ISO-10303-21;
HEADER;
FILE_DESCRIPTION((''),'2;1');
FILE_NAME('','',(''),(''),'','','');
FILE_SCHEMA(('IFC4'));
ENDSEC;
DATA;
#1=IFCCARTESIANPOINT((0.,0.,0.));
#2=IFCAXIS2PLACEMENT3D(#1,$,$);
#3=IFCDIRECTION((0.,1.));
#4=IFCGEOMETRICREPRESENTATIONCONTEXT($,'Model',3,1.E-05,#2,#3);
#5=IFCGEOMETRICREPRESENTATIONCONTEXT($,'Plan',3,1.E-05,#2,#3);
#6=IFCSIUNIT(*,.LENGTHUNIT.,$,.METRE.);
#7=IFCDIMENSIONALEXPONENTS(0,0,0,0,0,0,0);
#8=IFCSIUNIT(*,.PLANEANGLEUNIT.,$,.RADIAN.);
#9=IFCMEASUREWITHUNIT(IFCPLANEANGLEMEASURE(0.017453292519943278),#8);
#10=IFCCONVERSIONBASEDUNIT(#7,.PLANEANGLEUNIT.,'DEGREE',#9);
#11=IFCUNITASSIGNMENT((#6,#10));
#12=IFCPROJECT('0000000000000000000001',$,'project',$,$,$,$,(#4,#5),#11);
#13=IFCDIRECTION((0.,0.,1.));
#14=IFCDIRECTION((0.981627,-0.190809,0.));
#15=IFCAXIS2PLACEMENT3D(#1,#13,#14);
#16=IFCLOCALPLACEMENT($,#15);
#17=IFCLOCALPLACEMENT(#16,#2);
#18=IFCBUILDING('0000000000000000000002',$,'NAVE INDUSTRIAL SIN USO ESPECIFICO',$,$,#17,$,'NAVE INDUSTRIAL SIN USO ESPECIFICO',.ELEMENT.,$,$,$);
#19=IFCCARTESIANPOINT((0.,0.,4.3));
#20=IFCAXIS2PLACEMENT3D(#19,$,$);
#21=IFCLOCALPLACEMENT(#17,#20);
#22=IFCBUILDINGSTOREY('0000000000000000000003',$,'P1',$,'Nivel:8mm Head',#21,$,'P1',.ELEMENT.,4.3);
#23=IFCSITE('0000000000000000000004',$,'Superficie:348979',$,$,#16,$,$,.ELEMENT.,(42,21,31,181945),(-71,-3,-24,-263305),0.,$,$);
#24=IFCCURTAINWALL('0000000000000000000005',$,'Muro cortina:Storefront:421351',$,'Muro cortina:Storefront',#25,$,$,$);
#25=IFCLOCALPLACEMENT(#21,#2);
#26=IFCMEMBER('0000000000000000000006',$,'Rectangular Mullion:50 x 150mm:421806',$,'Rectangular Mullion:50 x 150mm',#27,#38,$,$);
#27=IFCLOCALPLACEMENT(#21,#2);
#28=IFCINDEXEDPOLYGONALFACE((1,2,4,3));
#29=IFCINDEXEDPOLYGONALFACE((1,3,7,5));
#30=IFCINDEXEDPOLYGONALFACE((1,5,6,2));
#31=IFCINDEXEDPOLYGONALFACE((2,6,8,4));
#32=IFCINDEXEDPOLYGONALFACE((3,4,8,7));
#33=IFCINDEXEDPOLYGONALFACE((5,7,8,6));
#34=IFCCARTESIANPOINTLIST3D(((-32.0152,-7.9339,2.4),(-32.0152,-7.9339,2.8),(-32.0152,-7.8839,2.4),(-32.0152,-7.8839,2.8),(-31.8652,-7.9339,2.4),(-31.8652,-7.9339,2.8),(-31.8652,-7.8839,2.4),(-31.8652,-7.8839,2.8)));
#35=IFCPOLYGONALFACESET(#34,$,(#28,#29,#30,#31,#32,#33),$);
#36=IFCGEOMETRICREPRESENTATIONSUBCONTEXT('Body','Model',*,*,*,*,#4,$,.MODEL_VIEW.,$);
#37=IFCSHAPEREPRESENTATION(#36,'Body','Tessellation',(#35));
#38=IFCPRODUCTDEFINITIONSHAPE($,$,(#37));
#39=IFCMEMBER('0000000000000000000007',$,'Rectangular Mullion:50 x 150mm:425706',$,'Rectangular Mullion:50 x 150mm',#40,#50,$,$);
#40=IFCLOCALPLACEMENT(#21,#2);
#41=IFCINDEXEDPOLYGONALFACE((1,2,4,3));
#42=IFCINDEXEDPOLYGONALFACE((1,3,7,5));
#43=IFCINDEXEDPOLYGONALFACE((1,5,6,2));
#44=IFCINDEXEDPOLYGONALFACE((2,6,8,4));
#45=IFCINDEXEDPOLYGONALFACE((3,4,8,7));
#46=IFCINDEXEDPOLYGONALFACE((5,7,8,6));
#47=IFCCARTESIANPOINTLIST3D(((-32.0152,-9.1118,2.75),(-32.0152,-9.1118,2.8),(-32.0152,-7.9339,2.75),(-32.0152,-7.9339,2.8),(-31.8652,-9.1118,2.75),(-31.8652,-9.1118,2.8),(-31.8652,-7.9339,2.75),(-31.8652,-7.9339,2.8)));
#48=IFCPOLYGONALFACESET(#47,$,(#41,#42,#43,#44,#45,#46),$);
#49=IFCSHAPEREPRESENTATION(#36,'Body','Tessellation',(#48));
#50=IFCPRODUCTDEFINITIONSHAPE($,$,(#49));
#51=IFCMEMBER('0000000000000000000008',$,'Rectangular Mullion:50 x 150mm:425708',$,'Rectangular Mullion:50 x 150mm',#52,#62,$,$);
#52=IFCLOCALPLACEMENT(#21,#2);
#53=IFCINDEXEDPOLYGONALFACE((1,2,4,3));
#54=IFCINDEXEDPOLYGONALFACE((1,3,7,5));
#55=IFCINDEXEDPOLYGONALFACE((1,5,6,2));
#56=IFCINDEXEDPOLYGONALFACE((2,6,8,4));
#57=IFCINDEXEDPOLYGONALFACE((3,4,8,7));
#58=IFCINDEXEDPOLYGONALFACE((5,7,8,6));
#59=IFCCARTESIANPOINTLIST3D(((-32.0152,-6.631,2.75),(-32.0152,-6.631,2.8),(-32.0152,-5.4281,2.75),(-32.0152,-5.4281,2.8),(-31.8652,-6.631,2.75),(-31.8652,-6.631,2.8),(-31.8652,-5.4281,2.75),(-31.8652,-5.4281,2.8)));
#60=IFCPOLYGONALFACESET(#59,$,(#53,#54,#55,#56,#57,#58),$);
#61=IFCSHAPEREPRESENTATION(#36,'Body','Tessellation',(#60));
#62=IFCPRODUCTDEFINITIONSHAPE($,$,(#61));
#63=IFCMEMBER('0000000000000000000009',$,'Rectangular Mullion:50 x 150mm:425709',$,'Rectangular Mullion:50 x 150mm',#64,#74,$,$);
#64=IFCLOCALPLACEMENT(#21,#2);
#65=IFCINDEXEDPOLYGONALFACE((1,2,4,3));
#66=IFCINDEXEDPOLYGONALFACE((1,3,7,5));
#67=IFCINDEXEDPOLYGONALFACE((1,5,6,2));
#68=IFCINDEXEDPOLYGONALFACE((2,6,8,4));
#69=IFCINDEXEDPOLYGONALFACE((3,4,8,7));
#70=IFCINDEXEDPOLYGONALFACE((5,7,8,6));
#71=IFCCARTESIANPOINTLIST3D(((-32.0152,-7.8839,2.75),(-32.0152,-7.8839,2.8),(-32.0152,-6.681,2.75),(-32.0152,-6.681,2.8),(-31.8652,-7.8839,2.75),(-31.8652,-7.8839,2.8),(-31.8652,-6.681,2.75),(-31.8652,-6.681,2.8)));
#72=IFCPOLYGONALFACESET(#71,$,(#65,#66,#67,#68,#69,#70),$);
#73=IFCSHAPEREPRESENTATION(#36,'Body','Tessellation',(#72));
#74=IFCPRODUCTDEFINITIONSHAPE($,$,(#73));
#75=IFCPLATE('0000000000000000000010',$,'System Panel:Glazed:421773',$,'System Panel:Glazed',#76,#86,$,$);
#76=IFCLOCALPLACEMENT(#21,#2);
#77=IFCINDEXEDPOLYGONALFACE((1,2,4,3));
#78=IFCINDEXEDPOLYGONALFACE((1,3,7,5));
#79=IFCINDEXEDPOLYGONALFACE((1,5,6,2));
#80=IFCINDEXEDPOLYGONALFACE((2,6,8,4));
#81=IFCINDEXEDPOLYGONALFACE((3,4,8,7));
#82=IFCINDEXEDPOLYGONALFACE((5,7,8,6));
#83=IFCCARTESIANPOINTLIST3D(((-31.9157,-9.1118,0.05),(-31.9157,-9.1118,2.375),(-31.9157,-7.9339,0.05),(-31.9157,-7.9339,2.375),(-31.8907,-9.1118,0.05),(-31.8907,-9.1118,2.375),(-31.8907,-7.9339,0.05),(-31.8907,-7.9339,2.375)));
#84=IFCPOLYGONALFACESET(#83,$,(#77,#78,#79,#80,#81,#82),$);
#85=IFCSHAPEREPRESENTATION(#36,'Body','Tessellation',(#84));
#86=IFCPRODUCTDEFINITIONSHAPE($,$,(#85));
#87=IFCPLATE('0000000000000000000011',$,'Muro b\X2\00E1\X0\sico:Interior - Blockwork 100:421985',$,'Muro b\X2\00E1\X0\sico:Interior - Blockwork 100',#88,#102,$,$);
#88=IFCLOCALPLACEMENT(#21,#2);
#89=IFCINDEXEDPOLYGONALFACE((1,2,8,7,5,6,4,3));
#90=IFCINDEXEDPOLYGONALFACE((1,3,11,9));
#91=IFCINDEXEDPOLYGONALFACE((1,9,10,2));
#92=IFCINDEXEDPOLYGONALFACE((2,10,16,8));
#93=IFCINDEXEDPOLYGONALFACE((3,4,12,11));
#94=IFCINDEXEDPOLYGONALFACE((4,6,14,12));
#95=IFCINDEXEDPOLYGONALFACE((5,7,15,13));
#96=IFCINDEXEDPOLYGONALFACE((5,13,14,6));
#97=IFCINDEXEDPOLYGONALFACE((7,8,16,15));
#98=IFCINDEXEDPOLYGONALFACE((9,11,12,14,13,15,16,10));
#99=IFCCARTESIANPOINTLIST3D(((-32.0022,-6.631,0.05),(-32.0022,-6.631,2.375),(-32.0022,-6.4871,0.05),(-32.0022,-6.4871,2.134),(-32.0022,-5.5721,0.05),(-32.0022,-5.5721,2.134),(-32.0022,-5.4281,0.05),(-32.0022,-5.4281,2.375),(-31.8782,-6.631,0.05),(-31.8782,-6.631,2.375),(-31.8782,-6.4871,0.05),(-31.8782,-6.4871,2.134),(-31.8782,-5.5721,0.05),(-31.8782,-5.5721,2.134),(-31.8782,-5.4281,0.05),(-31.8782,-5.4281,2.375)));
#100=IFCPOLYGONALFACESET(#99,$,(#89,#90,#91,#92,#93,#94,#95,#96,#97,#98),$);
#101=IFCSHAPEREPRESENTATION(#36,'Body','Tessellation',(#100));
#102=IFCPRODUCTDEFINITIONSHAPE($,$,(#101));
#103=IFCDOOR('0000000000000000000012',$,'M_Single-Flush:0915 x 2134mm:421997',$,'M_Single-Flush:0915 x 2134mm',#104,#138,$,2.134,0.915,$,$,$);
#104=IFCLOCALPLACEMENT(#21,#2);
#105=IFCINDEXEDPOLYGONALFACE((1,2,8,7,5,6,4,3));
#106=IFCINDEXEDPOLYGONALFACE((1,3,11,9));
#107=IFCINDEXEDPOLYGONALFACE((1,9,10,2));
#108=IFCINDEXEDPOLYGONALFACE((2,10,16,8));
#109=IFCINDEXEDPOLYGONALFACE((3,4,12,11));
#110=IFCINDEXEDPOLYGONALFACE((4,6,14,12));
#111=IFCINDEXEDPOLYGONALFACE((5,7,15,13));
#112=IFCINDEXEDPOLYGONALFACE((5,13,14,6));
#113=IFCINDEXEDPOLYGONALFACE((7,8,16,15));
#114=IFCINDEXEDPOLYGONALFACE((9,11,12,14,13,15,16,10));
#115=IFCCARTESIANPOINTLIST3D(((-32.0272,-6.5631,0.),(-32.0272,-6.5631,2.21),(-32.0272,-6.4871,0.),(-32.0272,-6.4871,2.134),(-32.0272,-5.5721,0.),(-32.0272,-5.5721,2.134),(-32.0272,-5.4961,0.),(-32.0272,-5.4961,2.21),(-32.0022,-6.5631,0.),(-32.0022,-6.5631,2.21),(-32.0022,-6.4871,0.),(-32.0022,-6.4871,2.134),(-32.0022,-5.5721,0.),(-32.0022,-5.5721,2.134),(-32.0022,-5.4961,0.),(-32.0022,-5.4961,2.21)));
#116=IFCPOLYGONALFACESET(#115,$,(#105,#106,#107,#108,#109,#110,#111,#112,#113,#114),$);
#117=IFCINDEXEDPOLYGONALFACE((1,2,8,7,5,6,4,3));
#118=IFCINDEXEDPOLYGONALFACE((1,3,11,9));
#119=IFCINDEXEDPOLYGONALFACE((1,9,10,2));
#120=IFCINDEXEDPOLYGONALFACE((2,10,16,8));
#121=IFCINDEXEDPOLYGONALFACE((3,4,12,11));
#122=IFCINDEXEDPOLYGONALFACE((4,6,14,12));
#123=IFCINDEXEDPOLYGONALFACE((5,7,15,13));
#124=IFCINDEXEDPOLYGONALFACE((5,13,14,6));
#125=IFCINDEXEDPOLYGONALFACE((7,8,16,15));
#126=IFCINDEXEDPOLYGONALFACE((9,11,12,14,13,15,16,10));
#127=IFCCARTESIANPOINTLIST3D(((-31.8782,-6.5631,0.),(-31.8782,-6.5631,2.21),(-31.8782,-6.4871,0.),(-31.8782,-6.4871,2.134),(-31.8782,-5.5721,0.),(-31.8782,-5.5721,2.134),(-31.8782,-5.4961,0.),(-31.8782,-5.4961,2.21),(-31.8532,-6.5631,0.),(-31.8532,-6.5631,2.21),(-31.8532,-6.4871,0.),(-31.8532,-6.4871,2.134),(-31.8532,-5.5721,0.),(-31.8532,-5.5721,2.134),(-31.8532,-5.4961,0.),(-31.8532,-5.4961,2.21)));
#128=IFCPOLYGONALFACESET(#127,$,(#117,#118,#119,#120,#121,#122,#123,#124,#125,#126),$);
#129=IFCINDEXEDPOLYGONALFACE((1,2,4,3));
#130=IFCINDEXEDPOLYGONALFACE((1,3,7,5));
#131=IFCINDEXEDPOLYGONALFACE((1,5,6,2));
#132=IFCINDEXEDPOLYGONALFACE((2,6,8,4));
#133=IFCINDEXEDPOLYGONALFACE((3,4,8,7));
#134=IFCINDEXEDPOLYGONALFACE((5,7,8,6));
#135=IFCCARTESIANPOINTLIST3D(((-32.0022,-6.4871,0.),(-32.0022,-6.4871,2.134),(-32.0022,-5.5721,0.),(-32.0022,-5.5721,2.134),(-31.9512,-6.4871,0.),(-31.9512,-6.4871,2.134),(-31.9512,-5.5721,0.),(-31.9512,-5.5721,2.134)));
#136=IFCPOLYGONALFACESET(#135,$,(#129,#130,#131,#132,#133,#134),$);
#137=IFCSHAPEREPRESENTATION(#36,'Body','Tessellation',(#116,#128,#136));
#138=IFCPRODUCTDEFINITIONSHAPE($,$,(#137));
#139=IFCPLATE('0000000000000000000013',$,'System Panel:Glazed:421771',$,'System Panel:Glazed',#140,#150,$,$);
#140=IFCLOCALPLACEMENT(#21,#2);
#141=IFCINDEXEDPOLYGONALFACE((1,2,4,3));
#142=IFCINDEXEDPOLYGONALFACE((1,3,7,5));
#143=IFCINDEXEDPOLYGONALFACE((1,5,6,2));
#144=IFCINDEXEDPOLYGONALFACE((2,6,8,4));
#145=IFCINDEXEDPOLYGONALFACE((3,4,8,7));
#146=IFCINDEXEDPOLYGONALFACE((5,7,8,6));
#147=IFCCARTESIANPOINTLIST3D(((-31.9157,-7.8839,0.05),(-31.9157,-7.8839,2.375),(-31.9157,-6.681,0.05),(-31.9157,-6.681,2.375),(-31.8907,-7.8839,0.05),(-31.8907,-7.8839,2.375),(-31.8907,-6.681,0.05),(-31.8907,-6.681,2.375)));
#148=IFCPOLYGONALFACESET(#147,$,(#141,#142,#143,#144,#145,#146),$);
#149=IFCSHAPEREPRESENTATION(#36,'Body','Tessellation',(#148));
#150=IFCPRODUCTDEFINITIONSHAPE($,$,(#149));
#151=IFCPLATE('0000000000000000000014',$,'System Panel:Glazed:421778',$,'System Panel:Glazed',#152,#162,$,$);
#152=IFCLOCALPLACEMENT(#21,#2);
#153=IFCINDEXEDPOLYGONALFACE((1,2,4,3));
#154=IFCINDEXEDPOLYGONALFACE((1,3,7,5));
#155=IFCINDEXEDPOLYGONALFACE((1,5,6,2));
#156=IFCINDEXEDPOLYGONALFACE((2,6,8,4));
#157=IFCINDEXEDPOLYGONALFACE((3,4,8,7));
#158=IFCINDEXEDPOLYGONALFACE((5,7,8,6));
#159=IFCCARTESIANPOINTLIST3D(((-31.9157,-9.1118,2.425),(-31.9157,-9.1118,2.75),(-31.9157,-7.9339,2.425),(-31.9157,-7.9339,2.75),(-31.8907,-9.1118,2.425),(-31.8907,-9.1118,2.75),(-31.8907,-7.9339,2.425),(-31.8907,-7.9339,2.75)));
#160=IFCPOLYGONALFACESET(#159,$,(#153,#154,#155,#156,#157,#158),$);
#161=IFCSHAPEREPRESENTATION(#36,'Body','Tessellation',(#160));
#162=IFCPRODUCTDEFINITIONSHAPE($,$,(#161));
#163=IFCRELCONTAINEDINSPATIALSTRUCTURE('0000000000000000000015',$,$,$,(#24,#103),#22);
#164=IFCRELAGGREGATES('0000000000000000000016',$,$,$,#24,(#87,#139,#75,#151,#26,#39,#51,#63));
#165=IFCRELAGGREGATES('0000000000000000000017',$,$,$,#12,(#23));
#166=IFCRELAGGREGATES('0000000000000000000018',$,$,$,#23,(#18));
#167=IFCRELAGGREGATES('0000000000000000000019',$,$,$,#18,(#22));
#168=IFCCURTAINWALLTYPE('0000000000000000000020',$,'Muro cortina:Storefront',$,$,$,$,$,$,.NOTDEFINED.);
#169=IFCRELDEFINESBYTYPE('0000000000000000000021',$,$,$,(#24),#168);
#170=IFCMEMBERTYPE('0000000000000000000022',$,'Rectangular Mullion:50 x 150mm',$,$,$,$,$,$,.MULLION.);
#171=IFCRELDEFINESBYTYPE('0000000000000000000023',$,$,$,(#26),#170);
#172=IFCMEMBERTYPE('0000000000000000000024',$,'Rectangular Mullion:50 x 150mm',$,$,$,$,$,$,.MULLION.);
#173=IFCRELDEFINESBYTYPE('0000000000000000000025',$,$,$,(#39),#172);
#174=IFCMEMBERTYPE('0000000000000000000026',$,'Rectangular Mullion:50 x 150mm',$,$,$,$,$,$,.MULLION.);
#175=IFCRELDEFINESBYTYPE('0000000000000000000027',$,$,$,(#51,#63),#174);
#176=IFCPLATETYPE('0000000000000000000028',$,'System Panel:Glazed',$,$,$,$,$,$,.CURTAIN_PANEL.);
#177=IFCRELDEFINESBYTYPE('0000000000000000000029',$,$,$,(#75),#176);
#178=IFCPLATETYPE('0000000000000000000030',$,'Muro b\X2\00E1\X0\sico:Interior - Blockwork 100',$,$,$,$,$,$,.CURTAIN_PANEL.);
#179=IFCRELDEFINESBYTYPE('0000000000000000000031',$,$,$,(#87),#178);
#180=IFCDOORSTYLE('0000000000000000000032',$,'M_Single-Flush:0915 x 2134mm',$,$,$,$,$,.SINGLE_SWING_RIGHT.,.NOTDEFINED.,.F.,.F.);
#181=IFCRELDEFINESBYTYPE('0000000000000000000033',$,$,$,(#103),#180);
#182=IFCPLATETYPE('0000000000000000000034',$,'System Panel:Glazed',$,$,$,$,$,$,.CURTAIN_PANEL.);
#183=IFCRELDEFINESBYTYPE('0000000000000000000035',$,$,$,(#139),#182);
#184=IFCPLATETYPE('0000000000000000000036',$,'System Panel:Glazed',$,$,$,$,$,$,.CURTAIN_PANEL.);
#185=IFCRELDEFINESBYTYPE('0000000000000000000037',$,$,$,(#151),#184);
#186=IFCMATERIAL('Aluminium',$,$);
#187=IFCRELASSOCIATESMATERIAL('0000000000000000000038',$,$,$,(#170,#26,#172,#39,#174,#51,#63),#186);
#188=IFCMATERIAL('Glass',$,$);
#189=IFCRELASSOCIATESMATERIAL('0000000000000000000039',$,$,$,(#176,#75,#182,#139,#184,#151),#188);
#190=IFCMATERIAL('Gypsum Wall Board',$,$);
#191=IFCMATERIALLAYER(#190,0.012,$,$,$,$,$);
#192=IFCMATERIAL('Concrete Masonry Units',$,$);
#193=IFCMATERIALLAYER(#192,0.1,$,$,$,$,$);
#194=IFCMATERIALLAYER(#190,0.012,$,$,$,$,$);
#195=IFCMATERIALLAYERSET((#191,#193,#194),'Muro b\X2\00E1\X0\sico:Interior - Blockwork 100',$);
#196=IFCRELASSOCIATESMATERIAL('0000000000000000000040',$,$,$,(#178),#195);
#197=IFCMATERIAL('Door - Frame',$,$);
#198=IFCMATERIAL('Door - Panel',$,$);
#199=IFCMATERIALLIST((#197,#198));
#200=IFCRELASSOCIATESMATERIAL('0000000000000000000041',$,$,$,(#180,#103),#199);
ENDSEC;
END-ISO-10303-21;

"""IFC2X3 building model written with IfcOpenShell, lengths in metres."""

from ifc_helpers import new_model, entity, si_unit, converted_unit, direction, frame, frame_2d, origin, origin_2d_with_axis, place, context, subcontext, project, spatial, polyline, rectangle, outline, extrude, source, transform, mapped, material, material_list, layer, layer_set, type_object, type_shapes, element, fill, aggregate, save


model = new_model("IFC2X3")

# Units and contexts
model_context = context("Model", 3, precision=1e-05, world=origin(), true_north=direction((0.0, 1.0)))
plan_context = context("Plan", 3, precision=1e-05, world=origin(), true_north=direction((0.0, 1.0)))
body_context = subcontext(model_context, "Body", "Model", "MODEL_VIEW")
ifc_project = project(units=[si_unit("LENGTHUNIT", "METRE"), converted_unit("PLANEANGLEUNIT", "DEGREE", entity("IfcPlaneAngleMeasure", 0.017453292519943278), si_unit("PLANEANGLEUNIT", "RADIAN"), dimensions=[0, 0, 0, 0, 0, 0, 0])], contexts=[model_context, plan_context])

# Site, building, storey
site_placement = place(None, frame((0.0, 0.0, 0.0), z_axis=(0.0, 0.0, 1.0), x_axis=(0.981627, -0.190809, 0.0)))
site = spatial("IfcSite", under=ifc_project, at=site_placement, Name="Superficie:348979", CompositionType="ELEMENT", RefLatitude=(42, 21, 31, 181945), RefLongitude=(-71, -3, -24, -263305), RefElevation=0.0)
building_placement = place(site_placement, origin())
building = spatial("IfcBuilding", under=site, at=building_placement, Name="NAVE INDUSTRIAL SIN USO ESPECIFICO", LongName="NAVE INDUSTRIAL SIN USO ESPECIFICO", CompositionType="ELEMENT")
storey_placement = place(building_placement, frame((0.0, 0.0, 4.3)))
storey = spatial("IfcBuildingStorey", under=building, at=storey_placement, Name="P1", ObjectType="Nivel:8mm Head", LongName="P1", CompositionType="ELEMENT", Elevation=4.3)

# Curtain wall, members, plates, opening, door
curtain_wall_type = type_object("IfcCurtainWallType", Name="Muro cortina:Storefront", PredefinedType="NOTDEFINED")
curtain_wall_placement = place(storey_placement, frame((0.0, 0.0, -4.3)))
curtain_wall = element("IfcCurtainWall", 1, at=curtain_wall_placement, inside=storey, type_object=curtain_wall_type, Name="Muro cortina:Storefront:421351", ObjectType="Muro cortina:Storefront")
ifc_material_1 = material(Name="Aluminium")
member_type_1 = type_object("IfcMemberType", Name="Rectangular Mullion:50 x 150mm", PredefinedType="MULLION", material=ifc_material_1)
shared_shape_1 = source(origin(), body_context, "Body", "SweptSolid", [
    extrude(rectangle(XDim=0.05, YDim=0.15, at=origin_2d_with_axis()), frame((0.0, 0.0, -0.4), z_axis=(0.0, 0.0, 1.0), x_axis=(-1.0, 0.0, 0.0)), (0.0, 0.0, 1.0), 0.4),
])
type_shapes(member_type_1, [shared_shape_1])
member_1_placement = place(curtain_wall_placement, frame((-31.9402, -7.9089, 6.7), z_axis=(0.0, 0.0, -1.0), x_axis=(0.0, -1.0, 0.0)))
member_1 = element("IfcMember", 2, at=member_1_placement, type_object=member_type_1, material=ifc_material_1, Name="Rectangular Mullion:50 x 150mm:421806", ObjectType="Rectangular Mullion:50 x 150mm", context=body_context, shape_type="MappedRepresentation", body=[
    mapped(shared_shape_1, transform((0.0, 0.0, 0.0), scale=1.0)),
])
member_type_2 = type_object("IfcMemberType", Name="Rectangular Mullion:50 x 150mm", PredefinedType="MULLION", material=ifc_material_1)
shared_shape_2 = source(origin(), body_context, "Body", "SweptSolid", [
    extrude(rectangle(XDim=0.05, YDim=0.15, at=origin_2d_with_axis()), frame((-0.025, 0.0, -1.1779), z_axis=(0.0, 0.0, 1.0), x_axis=(-1.0, 0.0, 0.0)), (0.0, 0.0, 1.0), 1.1779),
])
type_shapes(member_type_2, [shared_shape_2])
member_2_placement = place(curtain_wall_placement, frame((-31.9402, -9.1118, 7.1), z_axis=(0.0, -1.0, 0.0), x_axis=(0.0, 0.0, 1.0)))
member_2 = element("IfcMember", 3, at=member_2_placement, type_object=member_type_2, material=ifc_material_1, Name="Rectangular Mullion:50 x 150mm:425706", ObjectType="Rectangular Mullion:50 x 150mm", context=body_context, shape_type="MappedRepresentation", body=[
    mapped(shared_shape_2, transform((0.0, 0.0, 0.0), scale=1.0)),
])
member_type_3 = type_object("IfcMemberType", Name="Rectangular Mullion:50 x 150mm", PredefinedType="MULLION", material=ifc_material_1)
shared_shape_3 = source(origin(), body_context, "Body", "SweptSolid", [
    extrude(rectangle(XDim=0.05, YDim=0.15, at=origin_2d_with_axis()), frame((-0.025, 0.0, -1.2029), z_axis=(0.0, 0.0, 1.0), x_axis=(-1.0, 0.0, 0.0)), (0.0, 0.0, 1.0), 1.2029),
])
type_shapes(member_type_3, [shared_shape_3])
member_3_placement = place(curtain_wall_placement, frame((-31.9402, -6.631, 7.1), z_axis=(0.0, -1.0, 0.0), x_axis=(0.0, 0.0, 1.0)))
member_3 = element("IfcMember", 4, at=member_3_placement, type_object=member_type_3, material=ifc_material_1, Name="Rectangular Mullion:50 x 150mm:425708", ObjectType="Rectangular Mullion:50 x 150mm", context=body_context, shape_type="MappedRepresentation", body=[
    mapped(shared_shape_3, transform((0.0, 0.0, 0.0), scale=1.0)),
])
member_4_placement = place(curtain_wall_placement, frame((-31.9402, -7.8839, 7.1), z_axis=(0.0, -1.0, 0.0), x_axis=(0.0, 0.0, 1.0)))
member_4 = element("IfcMember", 5, at=member_4_placement, type_object=member_type_3, material=ifc_material_1, Name="Rectangular Mullion:50 x 150mm:425709", ObjectType="Rectangular Mullion:50 x 150mm", context=body_context, shape_type="MappedRepresentation", body=[
    mapped(shared_shape_3, transform((0.0, 0.0, 0.0), scale=1.0)),
])
ifc_material_2 = material(Name="Glass")
plate_type_1 = type_object("IfcPlateType", Name="System Panel:Glazed", PredefinedType="CURTAIN_PANEL", material=ifc_material_2)
shared_shape_4 = source(origin(), body_context, "Body", "SweptSolid", [
    extrude(rectangle(XDim=0.025, YDim=1.1779, at=origin_2d_with_axis()), frame((0.589, 0.0125, 0.0), z_axis=(0.0, 0.0, 1.0), x_axis=(0.0, 1.0, 0.0)), (0.0, 0.0, 1.0), 2.325),
])
type_shapes(plate_type_1, [shared_shape_4])
plate_1_placement = place(curtain_wall_placement, frame((-31.9157, -7.9339, 4.35), z_axis=(0.0, 0.0, 1.0), x_axis=(0.0, -1.0, 0.0)))
plate_1 = element("IfcPlate", 6, at=plate_1_placement, type_object=plate_type_1, material=ifc_material_2, Name="System Panel:Glazed:421773", ObjectType="System Panel:Glazed", context=body_context, shape_type="MappedRepresentation", body=[
    mapped(shared_shape_4, transform((0.0, 0.0, 0.0), scale=1.0)),
])
ifc_material_3 = material(Name="Gypsum Wall Board")
ifc_layer_1 = layer(ifc_material_3, 0.012)
ifc_material_4 = material(Name="Concrete Masonry Units")
ifc_layer_2 = layer(ifc_material_4, 0.1)
ifc_layer_3 = layer(ifc_material_3, 0.012)
ifc_layer_set_1 = layer_set([ifc_layer_1, ifc_layer_2, ifc_layer_3], Name="Muro básico:Interior - Blockwork 100")
plate_type_2 = type_object("IfcPlateType", Name="Muro básico:Interior - Blockwork 100", PredefinedType="CURTAIN_PANEL", material=ifc_layer_set_1)
plate_2_placement = place(storey_placement, frame((-31.9402, -5.4281, 0.05), z_axis=(0.0, 0.0, 1.0), x_axis=(0.0, -1.0, 0.0)))
plate_2 = element("IfcPlate", 7, at=plate_2_placement, type_object=plate_type_2, Name="Muro básico:Interior - Blockwork 100:421985", ObjectType="Muro básico:Interior - Blockwork 100", context=body_context, shape_type="SweptSolid", body=[
    extrude(outline(polyline([(-0.6014, -1.1023), (-0.4575, -1.1023), (-0.4575, 0.9817), (0.4575, 0.9817), (0.4575, -1.1023), (0.6014, -1.1023), (0.6014, 1.2227), (-0.6014, 1.2227), (-0.6014, -1.1023)])), frame((0.6014, -0.062, 1.1023), z_axis=(0.0, 1.0, 0.0), x_axis=(-1.0, 0.0, 0.0)), (0.0, 0.0, 1.0), 0.124),
])
opening_1_placement = place(plate_2_placement, frame((1.0589, 0.062, -0.05)))
opening_1 = element("IfcOpeningElement", 8, at=opening_1_placement, cuts=plate_2, ObjectType="Opening", context=body_context, shape_type="SweptSolid", body=[
    extrude(rectangle(XDim=0.915, YDim=2.134, at=frame_2d((1.067, 0.4575), x_axis=(0.0, 1.0))), frame((0.0, 0.0, 0.0), z_axis=(0.0, -1.0, 0.0), x_axis=(0.0, 0.0, 1.0)), (0.0, 0.0, 1.0), 0.124),
])
ifc_material_5 = material(Name="Door - Frame")
ifc_material_6 = material(Name="Door - Panel")
ifc_material_list = material_list([ifc_material_5, ifc_material_6])
door_style_1 = type_object("IfcDoorStyle", Name="M_Single-Flush:0915 x 2134mm", ConstructionType="NOTDEFINED", OperationType="SINGLE_SWING_RIGHT", ParameterTakesPrecedence=False, Sizeable=False, material=ifc_material_list)
shared_shape_5 = source(origin(), body_context, "Body", "SweptSolid", [
    extrude(outline(polyline([(-0.5335, -1.124), (0.5335, -1.124), (0.5335, 1.086), (0.4575, 1.086), (0.4575, -1.048), (-0.4575, -1.048), (-0.4575, 1.086), (-0.5335, 1.086), (-0.5335, -1.124)])), frame((0.4575, 0.124, 1.086), z_axis=(0.0, 1.0, 0.0), x_axis=(1.0, 0.0, 0.0)), (0.0, 0.0, 1.0), 0.025),
    extrude(outline(polyline([(-1.124, -0.5335), (1.086, -0.5335), (1.086, -0.4575), (-1.048, -0.4575), (-1.048, 0.4575), (1.086, 0.4575), (1.086, 0.5335), (-1.124, 0.5335), (-1.124, -0.5335)])), frame((0.4575, -0.025, 1.086), z_axis=(0.0, 1.0, 0.0), x_axis=(0.0, 0.0, -1.0)), (0.0, 0.0, 1.0), 0.025),
    extrude(rectangle(XDim=0.051, YDim=0.915, at=origin_2d_with_axis()), frame((0.4575, 0.0985, 0.0), z_axis=(0.0, 0.0, 1.0), x_axis=(0.0, 1.0, 0.0)), (0.0, 0.0, 1.0), 2.134),
])
type_shapes(door_style_1, [shared_shape_5])
door_1_placement = place(opening_1_placement, frame((0.0, 0.0, 0.0), z_axis=(0.0, 0.0, 1.0), x_axis=(-1.0, 0.0, 0.0)))
door_1 = element("IfcDoor", 9, at=door_1_placement, inside=storey, type_object=door_style_1, material=ifc_material_list, Name="M_Single-Flush:0915 x 2134mm:421997", ObjectType="M_Single-Flush:0915 x 2134mm", OverallHeight=2.134, OverallWidth=0.915, context=body_context, shape_type="MappedRepresentation", body=[
    mapped(shared_shape_5, transform((0.0, 0.0, 0.0), scale=1.0)),
])
fill(opening_1, door_1)
plate_type_3 = type_object("IfcPlateType", Name="System Panel:Glazed", PredefinedType="CURTAIN_PANEL", material=ifc_material_2)
shared_shape_6 = source(origin(), body_context, "Body", "SweptSolid", [
    extrude(rectangle(XDim=0.025, YDim=1.2029, at=origin_2d_with_axis()), frame((0.6014, 0.0125, 0.0), z_axis=(0.0, 0.0, 1.0), x_axis=(0.0, 1.0, 0.0)), (0.0, 0.0, 1.0), 2.325),
])
type_shapes(plate_type_3, [shared_shape_6])
plate_3_placement = place(curtain_wall_placement, frame((-31.9157, -6.681, 4.35), z_axis=(0.0, 0.0, 1.0), x_axis=(0.0, -1.0, 0.0)))
plate_3 = element("IfcPlate", 10, at=plate_3_placement, type_object=plate_type_3, material=ifc_material_2, Name="System Panel:Glazed:421771", ObjectType="System Panel:Glazed", context=body_context, shape_type="MappedRepresentation", body=[
    mapped(shared_shape_6, transform((0.0, 0.0, 0.0), scale=1.0)),
])
plate_type_4 = type_object("IfcPlateType", Name="System Panel:Glazed", PredefinedType="CURTAIN_PANEL", material=ifc_material_2)
shared_shape_7 = source(origin(), body_context, "Body", "SweptSolid", [
    extrude(rectangle(XDim=0.025, YDim=1.1779, at=origin_2d_with_axis()), frame((0.589, 0.0125, 0.0), z_axis=(0.0, 0.0, 1.0), x_axis=(0.0, 1.0, 0.0)), (0.0, 0.0, 1.0), 0.325),
])
type_shapes(plate_type_4, [shared_shape_7])
plate_4_placement = place(curtain_wall_placement, frame((-31.9157, -7.9339, 6.725), z_axis=(0.0, 0.0, 1.0), x_axis=(0.0, -1.0, 0.0)))
plate_4 = element("IfcPlate", 11, at=plate_4_placement, type_object=plate_type_4, material=ifc_material_2, Name="System Panel:Glazed:421778", ObjectType="System Panel:Glazed", context=body_context, shape_type="MappedRepresentation", body=[
    mapped(shared_shape_7, transform((0.0, 0.0, 0.0), scale=1.0)),
])
aggregate(curtain_wall, [plate_2, plate_3, plate_1, plate_4, member_1, member_2, member_3, member_4])

save(model, "model.ifc")
